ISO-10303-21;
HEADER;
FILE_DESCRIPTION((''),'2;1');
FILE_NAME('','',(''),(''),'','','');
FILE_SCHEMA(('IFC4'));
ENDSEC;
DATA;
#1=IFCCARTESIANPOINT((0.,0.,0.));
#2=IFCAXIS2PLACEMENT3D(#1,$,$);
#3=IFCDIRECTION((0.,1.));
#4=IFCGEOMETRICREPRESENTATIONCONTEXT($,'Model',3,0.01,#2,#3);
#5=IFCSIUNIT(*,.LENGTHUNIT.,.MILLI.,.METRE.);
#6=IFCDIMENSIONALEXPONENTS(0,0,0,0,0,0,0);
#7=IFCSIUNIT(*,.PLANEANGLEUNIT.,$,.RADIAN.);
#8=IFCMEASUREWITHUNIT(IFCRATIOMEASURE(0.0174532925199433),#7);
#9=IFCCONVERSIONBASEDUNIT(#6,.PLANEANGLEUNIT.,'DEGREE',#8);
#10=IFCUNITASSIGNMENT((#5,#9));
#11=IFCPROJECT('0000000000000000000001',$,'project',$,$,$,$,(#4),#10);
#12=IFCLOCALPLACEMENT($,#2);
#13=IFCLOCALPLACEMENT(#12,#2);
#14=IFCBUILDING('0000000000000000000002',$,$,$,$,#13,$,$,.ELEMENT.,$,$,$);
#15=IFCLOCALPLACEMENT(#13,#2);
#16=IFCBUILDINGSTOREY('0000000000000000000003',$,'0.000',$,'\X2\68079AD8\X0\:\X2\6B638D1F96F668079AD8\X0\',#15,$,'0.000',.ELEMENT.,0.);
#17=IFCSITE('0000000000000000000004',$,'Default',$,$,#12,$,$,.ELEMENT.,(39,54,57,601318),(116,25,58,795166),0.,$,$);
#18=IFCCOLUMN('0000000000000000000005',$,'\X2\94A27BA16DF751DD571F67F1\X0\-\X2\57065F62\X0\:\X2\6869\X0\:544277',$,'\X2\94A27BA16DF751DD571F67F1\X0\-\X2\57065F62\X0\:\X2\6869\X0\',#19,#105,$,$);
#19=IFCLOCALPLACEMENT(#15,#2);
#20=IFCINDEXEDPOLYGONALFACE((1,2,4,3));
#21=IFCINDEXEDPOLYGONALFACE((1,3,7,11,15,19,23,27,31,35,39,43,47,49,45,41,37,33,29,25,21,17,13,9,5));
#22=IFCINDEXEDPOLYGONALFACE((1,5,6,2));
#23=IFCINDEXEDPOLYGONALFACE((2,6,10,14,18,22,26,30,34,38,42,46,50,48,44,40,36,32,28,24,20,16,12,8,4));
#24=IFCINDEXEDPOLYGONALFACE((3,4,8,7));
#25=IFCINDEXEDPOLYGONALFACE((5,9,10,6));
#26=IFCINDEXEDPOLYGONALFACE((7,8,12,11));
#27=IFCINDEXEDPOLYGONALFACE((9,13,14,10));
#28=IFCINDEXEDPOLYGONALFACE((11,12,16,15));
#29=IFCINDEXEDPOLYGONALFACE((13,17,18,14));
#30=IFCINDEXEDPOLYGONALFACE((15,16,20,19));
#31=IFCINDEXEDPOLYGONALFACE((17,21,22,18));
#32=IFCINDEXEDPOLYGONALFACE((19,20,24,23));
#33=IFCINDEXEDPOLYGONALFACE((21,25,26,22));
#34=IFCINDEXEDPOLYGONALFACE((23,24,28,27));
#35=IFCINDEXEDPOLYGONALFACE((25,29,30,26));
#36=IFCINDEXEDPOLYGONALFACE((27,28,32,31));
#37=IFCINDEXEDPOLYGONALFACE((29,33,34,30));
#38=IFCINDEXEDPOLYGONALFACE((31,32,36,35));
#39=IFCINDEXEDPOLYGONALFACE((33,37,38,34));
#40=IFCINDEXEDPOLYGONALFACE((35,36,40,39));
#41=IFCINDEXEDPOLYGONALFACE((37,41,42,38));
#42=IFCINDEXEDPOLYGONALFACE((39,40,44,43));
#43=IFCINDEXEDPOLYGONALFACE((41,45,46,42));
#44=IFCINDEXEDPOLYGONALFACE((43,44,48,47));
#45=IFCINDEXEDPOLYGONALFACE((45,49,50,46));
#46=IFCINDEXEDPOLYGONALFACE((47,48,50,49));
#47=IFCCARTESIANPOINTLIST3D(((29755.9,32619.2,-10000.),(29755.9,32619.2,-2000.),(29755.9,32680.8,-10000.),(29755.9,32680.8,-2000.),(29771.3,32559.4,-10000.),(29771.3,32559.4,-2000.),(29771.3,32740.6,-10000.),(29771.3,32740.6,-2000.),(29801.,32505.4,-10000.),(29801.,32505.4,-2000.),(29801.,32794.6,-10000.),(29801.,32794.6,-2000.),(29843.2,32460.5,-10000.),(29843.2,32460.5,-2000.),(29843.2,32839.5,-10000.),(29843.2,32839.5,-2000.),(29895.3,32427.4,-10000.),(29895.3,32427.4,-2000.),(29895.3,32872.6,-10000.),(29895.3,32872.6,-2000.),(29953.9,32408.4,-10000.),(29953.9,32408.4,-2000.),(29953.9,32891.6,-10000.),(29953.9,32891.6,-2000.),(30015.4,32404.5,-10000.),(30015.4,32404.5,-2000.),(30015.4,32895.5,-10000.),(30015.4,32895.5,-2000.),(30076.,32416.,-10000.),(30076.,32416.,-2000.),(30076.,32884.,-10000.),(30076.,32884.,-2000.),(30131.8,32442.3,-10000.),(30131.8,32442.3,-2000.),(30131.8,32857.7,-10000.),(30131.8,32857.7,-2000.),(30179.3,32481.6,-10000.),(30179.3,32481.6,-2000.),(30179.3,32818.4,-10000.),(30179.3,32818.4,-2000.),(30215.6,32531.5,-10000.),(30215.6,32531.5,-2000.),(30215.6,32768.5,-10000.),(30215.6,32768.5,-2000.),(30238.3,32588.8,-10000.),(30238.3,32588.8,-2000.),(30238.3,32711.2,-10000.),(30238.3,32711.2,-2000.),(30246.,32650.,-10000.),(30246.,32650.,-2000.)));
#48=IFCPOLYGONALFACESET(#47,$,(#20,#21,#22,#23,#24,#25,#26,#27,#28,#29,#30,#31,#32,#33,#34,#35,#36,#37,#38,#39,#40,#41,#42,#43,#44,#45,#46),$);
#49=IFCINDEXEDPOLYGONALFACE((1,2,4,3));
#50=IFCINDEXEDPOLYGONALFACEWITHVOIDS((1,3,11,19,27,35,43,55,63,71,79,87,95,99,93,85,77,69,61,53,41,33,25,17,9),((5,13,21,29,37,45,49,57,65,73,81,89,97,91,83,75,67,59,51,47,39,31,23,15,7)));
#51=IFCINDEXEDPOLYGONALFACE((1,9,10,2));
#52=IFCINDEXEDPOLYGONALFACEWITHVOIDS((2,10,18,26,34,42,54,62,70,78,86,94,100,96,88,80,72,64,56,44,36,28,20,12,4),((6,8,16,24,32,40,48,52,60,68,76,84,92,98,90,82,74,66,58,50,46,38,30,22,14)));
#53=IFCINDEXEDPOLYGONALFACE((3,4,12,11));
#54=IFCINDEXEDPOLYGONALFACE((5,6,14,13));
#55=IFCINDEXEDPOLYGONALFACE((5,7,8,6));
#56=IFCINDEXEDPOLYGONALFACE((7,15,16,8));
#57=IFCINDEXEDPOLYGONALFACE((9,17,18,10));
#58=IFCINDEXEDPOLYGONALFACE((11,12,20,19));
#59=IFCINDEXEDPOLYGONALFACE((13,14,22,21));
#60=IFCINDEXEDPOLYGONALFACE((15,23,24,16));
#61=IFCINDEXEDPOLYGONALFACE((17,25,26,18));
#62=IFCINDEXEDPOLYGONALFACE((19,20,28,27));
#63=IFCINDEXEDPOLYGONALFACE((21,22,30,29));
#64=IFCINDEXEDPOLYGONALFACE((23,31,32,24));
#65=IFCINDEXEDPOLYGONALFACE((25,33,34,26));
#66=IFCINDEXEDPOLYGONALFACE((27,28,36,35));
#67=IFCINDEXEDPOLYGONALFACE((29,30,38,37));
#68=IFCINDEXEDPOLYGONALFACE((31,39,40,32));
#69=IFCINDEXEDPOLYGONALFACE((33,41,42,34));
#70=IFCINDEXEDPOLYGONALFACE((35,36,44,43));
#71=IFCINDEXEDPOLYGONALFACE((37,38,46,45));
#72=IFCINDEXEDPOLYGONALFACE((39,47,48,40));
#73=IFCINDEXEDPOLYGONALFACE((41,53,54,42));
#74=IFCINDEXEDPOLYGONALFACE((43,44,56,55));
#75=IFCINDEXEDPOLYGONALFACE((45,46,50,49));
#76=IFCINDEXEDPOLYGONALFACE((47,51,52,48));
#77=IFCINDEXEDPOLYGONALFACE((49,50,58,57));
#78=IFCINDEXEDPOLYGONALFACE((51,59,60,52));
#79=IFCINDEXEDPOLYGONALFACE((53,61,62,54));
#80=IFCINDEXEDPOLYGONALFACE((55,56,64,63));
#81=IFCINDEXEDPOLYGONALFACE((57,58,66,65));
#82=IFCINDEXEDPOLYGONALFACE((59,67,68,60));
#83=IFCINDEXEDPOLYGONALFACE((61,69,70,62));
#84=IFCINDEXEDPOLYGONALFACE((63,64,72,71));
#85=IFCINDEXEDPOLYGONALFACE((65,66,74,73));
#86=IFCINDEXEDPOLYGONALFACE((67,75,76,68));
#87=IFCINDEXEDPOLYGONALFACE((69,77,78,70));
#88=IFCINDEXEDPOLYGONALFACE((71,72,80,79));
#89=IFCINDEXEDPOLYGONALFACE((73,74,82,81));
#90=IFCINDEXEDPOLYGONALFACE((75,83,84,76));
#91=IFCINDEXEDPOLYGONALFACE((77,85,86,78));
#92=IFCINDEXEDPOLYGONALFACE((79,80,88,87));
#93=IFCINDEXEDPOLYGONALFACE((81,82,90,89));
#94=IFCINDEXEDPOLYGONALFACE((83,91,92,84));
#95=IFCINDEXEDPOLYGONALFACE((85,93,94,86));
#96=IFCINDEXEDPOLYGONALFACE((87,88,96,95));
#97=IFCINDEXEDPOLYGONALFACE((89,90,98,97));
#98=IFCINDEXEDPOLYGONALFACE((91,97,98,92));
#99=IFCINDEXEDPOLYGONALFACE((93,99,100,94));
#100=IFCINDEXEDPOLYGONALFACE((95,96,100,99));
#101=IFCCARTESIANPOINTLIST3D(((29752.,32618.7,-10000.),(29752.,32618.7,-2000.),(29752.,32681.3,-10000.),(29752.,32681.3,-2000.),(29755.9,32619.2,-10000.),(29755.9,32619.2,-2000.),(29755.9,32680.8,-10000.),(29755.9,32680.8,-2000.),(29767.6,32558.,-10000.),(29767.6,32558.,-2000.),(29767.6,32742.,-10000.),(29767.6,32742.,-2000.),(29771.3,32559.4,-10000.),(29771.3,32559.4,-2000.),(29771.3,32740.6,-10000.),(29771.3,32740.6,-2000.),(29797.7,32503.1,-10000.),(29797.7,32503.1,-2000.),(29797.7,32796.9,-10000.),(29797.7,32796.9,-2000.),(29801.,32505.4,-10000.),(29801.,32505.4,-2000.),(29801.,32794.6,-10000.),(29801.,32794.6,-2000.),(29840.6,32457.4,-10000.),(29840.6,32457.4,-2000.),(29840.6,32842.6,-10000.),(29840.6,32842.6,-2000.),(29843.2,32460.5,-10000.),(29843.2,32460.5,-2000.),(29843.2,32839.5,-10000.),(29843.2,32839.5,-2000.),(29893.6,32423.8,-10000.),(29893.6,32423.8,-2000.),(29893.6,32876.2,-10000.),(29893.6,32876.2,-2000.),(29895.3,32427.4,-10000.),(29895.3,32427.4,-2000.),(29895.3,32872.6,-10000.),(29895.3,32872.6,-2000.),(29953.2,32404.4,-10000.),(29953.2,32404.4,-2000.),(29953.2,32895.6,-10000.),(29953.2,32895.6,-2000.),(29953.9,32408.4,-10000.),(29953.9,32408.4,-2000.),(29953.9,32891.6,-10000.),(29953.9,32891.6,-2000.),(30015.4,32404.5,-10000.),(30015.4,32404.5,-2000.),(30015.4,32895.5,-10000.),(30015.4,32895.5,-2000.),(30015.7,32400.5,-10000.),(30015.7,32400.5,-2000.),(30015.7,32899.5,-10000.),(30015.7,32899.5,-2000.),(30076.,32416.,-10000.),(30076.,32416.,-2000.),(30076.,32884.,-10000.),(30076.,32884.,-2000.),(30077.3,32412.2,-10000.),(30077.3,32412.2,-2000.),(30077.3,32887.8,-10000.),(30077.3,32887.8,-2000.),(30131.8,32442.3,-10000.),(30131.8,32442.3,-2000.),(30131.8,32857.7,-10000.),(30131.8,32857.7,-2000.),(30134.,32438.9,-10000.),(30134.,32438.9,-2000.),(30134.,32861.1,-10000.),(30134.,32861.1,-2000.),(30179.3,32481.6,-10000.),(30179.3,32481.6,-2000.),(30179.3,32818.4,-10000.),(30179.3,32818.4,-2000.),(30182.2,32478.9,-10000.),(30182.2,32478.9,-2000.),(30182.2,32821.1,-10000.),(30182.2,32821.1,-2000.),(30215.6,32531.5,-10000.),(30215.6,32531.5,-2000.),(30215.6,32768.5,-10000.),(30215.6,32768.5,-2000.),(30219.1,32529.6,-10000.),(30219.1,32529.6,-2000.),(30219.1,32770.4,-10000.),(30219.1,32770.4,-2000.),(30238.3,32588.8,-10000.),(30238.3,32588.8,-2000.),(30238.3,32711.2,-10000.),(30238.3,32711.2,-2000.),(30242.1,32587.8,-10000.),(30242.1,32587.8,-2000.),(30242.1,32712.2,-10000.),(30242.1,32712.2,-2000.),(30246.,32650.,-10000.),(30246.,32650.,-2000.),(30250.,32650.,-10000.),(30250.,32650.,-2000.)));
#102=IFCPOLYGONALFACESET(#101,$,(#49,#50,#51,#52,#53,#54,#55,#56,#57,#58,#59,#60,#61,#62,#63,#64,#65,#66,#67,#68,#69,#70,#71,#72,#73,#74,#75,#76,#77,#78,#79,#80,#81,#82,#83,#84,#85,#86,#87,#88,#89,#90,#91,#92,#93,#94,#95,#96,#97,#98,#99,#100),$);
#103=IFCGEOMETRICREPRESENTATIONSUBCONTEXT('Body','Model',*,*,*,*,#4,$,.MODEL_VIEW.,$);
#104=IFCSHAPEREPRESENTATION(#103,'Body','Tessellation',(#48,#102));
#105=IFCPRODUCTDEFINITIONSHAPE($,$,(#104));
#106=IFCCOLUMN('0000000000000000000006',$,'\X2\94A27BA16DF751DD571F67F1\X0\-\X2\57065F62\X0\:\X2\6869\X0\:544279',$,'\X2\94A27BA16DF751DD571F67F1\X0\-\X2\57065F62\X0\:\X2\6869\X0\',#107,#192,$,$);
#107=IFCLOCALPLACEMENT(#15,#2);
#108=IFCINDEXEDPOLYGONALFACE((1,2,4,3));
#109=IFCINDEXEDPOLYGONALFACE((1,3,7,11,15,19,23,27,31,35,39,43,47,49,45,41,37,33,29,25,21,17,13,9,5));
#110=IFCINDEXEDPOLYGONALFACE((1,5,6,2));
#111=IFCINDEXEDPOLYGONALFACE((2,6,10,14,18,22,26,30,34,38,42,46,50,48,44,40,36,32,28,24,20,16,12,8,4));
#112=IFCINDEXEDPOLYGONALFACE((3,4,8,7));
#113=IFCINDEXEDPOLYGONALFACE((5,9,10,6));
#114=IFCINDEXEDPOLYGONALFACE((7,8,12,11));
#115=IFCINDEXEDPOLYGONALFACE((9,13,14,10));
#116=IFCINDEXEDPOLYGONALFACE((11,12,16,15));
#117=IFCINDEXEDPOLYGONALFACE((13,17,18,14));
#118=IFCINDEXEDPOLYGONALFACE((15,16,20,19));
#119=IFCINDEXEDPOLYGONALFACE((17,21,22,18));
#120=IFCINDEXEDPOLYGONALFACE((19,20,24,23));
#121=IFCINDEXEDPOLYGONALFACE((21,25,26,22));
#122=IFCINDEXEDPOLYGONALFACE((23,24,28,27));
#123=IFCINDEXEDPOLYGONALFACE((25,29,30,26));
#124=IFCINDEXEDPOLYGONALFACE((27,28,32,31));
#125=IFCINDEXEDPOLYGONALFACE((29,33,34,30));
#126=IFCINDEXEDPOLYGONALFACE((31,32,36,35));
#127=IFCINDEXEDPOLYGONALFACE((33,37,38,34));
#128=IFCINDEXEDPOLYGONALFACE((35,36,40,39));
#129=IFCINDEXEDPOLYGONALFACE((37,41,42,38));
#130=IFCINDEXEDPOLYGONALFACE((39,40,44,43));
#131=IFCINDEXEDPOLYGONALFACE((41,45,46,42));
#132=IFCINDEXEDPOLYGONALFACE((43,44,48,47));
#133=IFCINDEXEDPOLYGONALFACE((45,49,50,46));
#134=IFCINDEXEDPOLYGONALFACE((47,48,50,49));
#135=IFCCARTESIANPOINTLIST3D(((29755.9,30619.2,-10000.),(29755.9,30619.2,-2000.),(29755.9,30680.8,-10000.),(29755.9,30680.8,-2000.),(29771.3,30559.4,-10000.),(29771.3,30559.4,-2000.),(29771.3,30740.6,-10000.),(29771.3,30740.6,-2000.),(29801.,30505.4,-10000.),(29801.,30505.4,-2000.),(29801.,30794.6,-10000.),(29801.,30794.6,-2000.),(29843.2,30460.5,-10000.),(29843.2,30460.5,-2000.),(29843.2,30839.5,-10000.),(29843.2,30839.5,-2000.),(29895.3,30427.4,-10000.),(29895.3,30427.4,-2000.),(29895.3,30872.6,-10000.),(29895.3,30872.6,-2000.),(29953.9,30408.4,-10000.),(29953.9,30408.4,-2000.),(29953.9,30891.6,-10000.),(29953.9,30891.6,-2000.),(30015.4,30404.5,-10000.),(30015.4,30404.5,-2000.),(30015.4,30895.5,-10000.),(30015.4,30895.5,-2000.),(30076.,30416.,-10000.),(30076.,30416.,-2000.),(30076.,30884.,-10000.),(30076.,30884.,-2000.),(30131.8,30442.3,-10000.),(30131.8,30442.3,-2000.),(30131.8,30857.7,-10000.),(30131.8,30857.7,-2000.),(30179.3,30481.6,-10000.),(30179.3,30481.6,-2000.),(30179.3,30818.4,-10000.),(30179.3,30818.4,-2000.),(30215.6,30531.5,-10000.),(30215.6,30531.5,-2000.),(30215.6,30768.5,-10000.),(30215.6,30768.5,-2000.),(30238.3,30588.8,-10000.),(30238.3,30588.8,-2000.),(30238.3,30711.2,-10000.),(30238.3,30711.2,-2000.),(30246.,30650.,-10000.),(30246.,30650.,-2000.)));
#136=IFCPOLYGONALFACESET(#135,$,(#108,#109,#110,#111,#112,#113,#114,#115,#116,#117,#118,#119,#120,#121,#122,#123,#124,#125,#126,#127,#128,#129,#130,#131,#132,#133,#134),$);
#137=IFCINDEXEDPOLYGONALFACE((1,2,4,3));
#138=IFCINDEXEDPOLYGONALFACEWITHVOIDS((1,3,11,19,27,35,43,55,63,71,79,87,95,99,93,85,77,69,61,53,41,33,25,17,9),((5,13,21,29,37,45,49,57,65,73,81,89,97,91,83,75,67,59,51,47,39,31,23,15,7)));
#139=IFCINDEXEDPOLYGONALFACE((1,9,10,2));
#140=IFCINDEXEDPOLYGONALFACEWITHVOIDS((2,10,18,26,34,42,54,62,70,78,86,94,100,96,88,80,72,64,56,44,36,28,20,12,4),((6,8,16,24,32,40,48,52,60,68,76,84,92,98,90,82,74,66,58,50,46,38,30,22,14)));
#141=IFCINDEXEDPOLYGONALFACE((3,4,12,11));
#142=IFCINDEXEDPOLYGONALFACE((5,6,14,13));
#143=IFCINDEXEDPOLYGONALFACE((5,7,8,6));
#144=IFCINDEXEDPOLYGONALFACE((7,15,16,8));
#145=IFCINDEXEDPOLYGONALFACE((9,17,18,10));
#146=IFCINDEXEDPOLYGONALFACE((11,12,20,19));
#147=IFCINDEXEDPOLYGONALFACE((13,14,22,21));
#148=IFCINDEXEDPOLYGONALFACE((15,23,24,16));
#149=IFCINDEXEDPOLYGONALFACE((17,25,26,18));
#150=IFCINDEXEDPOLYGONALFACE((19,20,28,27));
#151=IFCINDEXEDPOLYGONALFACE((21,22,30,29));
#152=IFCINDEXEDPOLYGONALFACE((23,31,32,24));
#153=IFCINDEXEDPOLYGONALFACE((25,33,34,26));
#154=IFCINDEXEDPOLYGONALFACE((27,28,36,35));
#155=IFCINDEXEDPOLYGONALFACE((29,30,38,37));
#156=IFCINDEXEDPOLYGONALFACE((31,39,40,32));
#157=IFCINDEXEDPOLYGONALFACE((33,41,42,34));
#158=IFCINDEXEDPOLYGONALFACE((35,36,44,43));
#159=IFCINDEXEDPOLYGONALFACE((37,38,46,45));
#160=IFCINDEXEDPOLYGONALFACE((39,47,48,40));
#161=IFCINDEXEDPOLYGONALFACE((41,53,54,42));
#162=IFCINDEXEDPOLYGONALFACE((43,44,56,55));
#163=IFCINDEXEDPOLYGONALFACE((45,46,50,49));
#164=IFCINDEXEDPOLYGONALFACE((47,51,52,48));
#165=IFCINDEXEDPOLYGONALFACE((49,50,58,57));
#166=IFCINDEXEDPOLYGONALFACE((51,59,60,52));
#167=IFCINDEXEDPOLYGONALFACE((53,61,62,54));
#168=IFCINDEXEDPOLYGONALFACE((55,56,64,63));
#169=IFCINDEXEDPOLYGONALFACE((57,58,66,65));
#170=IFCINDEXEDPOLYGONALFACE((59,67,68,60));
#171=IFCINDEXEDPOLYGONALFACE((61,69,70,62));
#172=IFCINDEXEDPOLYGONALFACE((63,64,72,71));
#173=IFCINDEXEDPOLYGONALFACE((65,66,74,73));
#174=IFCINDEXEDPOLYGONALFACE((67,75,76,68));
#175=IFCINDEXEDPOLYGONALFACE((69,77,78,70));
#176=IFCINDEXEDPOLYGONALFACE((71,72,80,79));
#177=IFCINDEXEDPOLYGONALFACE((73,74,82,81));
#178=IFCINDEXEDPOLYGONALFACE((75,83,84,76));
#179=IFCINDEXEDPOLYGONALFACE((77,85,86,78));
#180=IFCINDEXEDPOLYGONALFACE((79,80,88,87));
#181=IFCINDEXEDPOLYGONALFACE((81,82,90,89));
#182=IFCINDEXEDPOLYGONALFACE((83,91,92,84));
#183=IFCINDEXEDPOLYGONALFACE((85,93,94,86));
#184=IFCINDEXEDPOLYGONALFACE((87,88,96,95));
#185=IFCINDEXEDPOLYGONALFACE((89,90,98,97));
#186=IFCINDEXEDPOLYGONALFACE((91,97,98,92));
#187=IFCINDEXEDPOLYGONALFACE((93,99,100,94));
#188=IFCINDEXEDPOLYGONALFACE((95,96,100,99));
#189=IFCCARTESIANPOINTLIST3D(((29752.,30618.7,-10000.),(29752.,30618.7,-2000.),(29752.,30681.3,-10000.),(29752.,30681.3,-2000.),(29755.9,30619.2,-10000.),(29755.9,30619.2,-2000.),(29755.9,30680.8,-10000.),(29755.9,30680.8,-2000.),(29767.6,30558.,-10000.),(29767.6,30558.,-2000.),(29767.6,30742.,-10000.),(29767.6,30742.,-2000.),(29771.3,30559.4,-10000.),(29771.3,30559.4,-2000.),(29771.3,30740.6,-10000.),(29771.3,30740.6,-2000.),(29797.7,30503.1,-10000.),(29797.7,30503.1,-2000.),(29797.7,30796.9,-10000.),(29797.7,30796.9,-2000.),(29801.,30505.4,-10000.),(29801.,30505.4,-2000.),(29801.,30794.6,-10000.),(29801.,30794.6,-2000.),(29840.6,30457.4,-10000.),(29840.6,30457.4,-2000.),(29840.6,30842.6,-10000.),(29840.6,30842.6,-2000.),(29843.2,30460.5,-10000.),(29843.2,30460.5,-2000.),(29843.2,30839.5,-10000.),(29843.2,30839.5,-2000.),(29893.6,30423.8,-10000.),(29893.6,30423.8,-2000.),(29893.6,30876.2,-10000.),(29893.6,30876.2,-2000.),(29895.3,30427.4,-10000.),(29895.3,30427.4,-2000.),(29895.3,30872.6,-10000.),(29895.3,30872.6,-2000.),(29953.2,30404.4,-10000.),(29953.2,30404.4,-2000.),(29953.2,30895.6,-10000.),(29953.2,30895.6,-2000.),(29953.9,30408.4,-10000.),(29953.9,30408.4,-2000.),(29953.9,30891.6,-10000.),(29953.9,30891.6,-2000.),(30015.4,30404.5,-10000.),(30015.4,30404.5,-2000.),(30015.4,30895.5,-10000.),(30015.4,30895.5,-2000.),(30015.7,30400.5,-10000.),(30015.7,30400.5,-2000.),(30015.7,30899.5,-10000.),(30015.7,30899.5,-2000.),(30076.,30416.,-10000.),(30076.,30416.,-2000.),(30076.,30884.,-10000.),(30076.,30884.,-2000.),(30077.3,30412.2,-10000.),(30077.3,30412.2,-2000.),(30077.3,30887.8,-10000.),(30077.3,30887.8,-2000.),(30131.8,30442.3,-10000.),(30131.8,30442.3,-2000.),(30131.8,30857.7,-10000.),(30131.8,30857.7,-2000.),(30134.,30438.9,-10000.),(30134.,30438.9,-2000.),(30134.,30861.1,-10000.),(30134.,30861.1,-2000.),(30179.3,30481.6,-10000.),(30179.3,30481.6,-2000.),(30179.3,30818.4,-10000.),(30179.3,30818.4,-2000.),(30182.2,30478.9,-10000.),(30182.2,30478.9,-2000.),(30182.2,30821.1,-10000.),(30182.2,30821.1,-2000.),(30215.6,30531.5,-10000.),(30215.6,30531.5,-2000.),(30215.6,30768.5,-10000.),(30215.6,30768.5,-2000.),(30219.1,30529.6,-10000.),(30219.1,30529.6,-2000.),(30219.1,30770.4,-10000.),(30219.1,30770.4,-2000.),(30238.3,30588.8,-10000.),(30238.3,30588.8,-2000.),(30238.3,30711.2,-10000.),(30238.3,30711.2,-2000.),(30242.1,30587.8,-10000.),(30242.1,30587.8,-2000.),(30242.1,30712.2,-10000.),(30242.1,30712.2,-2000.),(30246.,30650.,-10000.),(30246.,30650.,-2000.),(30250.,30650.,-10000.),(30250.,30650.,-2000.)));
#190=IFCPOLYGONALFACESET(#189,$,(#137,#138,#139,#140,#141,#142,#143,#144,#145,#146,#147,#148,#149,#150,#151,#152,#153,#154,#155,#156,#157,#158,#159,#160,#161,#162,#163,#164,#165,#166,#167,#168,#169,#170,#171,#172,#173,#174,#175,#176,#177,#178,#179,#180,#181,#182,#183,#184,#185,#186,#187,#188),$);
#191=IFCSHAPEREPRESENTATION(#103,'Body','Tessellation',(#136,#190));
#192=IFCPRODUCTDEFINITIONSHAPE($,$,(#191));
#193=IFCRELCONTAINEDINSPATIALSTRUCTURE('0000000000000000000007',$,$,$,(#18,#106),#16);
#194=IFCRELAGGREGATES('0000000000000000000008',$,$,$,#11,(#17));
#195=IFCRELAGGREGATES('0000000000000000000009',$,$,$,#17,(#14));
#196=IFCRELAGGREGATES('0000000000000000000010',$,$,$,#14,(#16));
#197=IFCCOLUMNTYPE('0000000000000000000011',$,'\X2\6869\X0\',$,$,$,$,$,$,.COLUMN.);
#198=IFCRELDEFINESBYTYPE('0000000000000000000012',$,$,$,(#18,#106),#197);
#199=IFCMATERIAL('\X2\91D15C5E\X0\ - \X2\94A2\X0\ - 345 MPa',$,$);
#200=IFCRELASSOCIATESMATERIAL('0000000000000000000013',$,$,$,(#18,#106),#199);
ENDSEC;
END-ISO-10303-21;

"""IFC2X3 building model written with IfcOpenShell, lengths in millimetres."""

from ifc_helpers import new_model, entity, si_unit, converted_unit, direction, frame, frame_2d, origin, place, context, subcontext, project, spatial, circle, hollow_circle, extrude, source, transform, mapped, material, type_object, type_shapes, element, save


model = new_model("IFC2X3")

# Units and contexts
model_context = context("Model", 3, precision=0.01, world=origin(), true_north=direction((0.0, 1.0)))
body_context = subcontext(model_context, "Body", "Model", "MODEL_VIEW")
ifc_project = project(units=[si_unit("LENGTHUNIT", "METRE", prefix="MILLI"), converted_unit("PLANEANGLEUNIT", "DEGREE", entity("IfcRatioMeasure", 0.0174532925199433), si_unit("PLANEANGLEUNIT", "RADIAN"), dimensions=[0, 0, 0, 0, 0, 0, 0])], contexts=[model_context])

# Site, building, storey
site_placement = place(None, origin())
site = spatial("IfcSite", under=ifc_project, at=site_placement, Name="Default", CompositionType="ELEMENT", RefLatitude=(39, 54, 57, 601318), RefLongitude=(116, 25, 58, 795166), RefElevation=0.0)
building_placement = place(site_placement, origin())
building = spatial("IfcBuilding", under=site, at=building_placement, CompositionType="ELEMENT")
storey_placement = place(building_placement, origin())
storey = spatial("IfcBuildingStorey", under=building, at=storey_placement, Name="0.000", ObjectType="标高:正负零标高", LongName="0.000", CompositionType="ELEMENT", Elevation=0.0)

# Columns
ifc_material_1 = material(Name="金属 - 钢 - 345 MPa")
column_type_1 = type_object("IfcColumnType", Name="桩", PredefinedType="COLUMN")
shared_shape_1 = source(origin(), body_context, "Body", "SweptSolid", [
    extrude(circle(Radius=246.0, at=frame_2d((0.0, 0.0), x_axis=(1.0, 0.0))), frame((0.0, 0.0, -10000.0)), (0.0, 0.0, 1.0), 8000.0),
    extrude(hollow_circle(Radius=250.0, WallThickness=4.0, at=frame_2d((0.0, 0.0), x_axis=(1.0, 0.0))), frame((0.0, 0.0, -10000.0)), (0.0, 0.0, 1.0), 8000.0),
])
type_shapes(column_type_1, [shared_shape_1])
for number, where, name in (
    (1, (30000.0, 32650.0, 0.0), "钢管混凝土柱-圆形:桩:544277"),
    (2, (30000.0, 30650.0, 0.0), "钢管混凝土柱-圆形:桩:544279"),
):
    element("IfcColumn", number, at=place(storey_placement, frame(where)), inside=storey, type_object=column_type_1, material=ifc_material_1, Name=name, ObjectType="钢管混凝土柱-圆形:桩", context=body_context, shape_type="MappedRepresentation", body=[
        mapped(shared_shape_1, transform((0.0, 0.0, 0.0), scale=1.0)),
    ])

save(model, "model.ifc")
